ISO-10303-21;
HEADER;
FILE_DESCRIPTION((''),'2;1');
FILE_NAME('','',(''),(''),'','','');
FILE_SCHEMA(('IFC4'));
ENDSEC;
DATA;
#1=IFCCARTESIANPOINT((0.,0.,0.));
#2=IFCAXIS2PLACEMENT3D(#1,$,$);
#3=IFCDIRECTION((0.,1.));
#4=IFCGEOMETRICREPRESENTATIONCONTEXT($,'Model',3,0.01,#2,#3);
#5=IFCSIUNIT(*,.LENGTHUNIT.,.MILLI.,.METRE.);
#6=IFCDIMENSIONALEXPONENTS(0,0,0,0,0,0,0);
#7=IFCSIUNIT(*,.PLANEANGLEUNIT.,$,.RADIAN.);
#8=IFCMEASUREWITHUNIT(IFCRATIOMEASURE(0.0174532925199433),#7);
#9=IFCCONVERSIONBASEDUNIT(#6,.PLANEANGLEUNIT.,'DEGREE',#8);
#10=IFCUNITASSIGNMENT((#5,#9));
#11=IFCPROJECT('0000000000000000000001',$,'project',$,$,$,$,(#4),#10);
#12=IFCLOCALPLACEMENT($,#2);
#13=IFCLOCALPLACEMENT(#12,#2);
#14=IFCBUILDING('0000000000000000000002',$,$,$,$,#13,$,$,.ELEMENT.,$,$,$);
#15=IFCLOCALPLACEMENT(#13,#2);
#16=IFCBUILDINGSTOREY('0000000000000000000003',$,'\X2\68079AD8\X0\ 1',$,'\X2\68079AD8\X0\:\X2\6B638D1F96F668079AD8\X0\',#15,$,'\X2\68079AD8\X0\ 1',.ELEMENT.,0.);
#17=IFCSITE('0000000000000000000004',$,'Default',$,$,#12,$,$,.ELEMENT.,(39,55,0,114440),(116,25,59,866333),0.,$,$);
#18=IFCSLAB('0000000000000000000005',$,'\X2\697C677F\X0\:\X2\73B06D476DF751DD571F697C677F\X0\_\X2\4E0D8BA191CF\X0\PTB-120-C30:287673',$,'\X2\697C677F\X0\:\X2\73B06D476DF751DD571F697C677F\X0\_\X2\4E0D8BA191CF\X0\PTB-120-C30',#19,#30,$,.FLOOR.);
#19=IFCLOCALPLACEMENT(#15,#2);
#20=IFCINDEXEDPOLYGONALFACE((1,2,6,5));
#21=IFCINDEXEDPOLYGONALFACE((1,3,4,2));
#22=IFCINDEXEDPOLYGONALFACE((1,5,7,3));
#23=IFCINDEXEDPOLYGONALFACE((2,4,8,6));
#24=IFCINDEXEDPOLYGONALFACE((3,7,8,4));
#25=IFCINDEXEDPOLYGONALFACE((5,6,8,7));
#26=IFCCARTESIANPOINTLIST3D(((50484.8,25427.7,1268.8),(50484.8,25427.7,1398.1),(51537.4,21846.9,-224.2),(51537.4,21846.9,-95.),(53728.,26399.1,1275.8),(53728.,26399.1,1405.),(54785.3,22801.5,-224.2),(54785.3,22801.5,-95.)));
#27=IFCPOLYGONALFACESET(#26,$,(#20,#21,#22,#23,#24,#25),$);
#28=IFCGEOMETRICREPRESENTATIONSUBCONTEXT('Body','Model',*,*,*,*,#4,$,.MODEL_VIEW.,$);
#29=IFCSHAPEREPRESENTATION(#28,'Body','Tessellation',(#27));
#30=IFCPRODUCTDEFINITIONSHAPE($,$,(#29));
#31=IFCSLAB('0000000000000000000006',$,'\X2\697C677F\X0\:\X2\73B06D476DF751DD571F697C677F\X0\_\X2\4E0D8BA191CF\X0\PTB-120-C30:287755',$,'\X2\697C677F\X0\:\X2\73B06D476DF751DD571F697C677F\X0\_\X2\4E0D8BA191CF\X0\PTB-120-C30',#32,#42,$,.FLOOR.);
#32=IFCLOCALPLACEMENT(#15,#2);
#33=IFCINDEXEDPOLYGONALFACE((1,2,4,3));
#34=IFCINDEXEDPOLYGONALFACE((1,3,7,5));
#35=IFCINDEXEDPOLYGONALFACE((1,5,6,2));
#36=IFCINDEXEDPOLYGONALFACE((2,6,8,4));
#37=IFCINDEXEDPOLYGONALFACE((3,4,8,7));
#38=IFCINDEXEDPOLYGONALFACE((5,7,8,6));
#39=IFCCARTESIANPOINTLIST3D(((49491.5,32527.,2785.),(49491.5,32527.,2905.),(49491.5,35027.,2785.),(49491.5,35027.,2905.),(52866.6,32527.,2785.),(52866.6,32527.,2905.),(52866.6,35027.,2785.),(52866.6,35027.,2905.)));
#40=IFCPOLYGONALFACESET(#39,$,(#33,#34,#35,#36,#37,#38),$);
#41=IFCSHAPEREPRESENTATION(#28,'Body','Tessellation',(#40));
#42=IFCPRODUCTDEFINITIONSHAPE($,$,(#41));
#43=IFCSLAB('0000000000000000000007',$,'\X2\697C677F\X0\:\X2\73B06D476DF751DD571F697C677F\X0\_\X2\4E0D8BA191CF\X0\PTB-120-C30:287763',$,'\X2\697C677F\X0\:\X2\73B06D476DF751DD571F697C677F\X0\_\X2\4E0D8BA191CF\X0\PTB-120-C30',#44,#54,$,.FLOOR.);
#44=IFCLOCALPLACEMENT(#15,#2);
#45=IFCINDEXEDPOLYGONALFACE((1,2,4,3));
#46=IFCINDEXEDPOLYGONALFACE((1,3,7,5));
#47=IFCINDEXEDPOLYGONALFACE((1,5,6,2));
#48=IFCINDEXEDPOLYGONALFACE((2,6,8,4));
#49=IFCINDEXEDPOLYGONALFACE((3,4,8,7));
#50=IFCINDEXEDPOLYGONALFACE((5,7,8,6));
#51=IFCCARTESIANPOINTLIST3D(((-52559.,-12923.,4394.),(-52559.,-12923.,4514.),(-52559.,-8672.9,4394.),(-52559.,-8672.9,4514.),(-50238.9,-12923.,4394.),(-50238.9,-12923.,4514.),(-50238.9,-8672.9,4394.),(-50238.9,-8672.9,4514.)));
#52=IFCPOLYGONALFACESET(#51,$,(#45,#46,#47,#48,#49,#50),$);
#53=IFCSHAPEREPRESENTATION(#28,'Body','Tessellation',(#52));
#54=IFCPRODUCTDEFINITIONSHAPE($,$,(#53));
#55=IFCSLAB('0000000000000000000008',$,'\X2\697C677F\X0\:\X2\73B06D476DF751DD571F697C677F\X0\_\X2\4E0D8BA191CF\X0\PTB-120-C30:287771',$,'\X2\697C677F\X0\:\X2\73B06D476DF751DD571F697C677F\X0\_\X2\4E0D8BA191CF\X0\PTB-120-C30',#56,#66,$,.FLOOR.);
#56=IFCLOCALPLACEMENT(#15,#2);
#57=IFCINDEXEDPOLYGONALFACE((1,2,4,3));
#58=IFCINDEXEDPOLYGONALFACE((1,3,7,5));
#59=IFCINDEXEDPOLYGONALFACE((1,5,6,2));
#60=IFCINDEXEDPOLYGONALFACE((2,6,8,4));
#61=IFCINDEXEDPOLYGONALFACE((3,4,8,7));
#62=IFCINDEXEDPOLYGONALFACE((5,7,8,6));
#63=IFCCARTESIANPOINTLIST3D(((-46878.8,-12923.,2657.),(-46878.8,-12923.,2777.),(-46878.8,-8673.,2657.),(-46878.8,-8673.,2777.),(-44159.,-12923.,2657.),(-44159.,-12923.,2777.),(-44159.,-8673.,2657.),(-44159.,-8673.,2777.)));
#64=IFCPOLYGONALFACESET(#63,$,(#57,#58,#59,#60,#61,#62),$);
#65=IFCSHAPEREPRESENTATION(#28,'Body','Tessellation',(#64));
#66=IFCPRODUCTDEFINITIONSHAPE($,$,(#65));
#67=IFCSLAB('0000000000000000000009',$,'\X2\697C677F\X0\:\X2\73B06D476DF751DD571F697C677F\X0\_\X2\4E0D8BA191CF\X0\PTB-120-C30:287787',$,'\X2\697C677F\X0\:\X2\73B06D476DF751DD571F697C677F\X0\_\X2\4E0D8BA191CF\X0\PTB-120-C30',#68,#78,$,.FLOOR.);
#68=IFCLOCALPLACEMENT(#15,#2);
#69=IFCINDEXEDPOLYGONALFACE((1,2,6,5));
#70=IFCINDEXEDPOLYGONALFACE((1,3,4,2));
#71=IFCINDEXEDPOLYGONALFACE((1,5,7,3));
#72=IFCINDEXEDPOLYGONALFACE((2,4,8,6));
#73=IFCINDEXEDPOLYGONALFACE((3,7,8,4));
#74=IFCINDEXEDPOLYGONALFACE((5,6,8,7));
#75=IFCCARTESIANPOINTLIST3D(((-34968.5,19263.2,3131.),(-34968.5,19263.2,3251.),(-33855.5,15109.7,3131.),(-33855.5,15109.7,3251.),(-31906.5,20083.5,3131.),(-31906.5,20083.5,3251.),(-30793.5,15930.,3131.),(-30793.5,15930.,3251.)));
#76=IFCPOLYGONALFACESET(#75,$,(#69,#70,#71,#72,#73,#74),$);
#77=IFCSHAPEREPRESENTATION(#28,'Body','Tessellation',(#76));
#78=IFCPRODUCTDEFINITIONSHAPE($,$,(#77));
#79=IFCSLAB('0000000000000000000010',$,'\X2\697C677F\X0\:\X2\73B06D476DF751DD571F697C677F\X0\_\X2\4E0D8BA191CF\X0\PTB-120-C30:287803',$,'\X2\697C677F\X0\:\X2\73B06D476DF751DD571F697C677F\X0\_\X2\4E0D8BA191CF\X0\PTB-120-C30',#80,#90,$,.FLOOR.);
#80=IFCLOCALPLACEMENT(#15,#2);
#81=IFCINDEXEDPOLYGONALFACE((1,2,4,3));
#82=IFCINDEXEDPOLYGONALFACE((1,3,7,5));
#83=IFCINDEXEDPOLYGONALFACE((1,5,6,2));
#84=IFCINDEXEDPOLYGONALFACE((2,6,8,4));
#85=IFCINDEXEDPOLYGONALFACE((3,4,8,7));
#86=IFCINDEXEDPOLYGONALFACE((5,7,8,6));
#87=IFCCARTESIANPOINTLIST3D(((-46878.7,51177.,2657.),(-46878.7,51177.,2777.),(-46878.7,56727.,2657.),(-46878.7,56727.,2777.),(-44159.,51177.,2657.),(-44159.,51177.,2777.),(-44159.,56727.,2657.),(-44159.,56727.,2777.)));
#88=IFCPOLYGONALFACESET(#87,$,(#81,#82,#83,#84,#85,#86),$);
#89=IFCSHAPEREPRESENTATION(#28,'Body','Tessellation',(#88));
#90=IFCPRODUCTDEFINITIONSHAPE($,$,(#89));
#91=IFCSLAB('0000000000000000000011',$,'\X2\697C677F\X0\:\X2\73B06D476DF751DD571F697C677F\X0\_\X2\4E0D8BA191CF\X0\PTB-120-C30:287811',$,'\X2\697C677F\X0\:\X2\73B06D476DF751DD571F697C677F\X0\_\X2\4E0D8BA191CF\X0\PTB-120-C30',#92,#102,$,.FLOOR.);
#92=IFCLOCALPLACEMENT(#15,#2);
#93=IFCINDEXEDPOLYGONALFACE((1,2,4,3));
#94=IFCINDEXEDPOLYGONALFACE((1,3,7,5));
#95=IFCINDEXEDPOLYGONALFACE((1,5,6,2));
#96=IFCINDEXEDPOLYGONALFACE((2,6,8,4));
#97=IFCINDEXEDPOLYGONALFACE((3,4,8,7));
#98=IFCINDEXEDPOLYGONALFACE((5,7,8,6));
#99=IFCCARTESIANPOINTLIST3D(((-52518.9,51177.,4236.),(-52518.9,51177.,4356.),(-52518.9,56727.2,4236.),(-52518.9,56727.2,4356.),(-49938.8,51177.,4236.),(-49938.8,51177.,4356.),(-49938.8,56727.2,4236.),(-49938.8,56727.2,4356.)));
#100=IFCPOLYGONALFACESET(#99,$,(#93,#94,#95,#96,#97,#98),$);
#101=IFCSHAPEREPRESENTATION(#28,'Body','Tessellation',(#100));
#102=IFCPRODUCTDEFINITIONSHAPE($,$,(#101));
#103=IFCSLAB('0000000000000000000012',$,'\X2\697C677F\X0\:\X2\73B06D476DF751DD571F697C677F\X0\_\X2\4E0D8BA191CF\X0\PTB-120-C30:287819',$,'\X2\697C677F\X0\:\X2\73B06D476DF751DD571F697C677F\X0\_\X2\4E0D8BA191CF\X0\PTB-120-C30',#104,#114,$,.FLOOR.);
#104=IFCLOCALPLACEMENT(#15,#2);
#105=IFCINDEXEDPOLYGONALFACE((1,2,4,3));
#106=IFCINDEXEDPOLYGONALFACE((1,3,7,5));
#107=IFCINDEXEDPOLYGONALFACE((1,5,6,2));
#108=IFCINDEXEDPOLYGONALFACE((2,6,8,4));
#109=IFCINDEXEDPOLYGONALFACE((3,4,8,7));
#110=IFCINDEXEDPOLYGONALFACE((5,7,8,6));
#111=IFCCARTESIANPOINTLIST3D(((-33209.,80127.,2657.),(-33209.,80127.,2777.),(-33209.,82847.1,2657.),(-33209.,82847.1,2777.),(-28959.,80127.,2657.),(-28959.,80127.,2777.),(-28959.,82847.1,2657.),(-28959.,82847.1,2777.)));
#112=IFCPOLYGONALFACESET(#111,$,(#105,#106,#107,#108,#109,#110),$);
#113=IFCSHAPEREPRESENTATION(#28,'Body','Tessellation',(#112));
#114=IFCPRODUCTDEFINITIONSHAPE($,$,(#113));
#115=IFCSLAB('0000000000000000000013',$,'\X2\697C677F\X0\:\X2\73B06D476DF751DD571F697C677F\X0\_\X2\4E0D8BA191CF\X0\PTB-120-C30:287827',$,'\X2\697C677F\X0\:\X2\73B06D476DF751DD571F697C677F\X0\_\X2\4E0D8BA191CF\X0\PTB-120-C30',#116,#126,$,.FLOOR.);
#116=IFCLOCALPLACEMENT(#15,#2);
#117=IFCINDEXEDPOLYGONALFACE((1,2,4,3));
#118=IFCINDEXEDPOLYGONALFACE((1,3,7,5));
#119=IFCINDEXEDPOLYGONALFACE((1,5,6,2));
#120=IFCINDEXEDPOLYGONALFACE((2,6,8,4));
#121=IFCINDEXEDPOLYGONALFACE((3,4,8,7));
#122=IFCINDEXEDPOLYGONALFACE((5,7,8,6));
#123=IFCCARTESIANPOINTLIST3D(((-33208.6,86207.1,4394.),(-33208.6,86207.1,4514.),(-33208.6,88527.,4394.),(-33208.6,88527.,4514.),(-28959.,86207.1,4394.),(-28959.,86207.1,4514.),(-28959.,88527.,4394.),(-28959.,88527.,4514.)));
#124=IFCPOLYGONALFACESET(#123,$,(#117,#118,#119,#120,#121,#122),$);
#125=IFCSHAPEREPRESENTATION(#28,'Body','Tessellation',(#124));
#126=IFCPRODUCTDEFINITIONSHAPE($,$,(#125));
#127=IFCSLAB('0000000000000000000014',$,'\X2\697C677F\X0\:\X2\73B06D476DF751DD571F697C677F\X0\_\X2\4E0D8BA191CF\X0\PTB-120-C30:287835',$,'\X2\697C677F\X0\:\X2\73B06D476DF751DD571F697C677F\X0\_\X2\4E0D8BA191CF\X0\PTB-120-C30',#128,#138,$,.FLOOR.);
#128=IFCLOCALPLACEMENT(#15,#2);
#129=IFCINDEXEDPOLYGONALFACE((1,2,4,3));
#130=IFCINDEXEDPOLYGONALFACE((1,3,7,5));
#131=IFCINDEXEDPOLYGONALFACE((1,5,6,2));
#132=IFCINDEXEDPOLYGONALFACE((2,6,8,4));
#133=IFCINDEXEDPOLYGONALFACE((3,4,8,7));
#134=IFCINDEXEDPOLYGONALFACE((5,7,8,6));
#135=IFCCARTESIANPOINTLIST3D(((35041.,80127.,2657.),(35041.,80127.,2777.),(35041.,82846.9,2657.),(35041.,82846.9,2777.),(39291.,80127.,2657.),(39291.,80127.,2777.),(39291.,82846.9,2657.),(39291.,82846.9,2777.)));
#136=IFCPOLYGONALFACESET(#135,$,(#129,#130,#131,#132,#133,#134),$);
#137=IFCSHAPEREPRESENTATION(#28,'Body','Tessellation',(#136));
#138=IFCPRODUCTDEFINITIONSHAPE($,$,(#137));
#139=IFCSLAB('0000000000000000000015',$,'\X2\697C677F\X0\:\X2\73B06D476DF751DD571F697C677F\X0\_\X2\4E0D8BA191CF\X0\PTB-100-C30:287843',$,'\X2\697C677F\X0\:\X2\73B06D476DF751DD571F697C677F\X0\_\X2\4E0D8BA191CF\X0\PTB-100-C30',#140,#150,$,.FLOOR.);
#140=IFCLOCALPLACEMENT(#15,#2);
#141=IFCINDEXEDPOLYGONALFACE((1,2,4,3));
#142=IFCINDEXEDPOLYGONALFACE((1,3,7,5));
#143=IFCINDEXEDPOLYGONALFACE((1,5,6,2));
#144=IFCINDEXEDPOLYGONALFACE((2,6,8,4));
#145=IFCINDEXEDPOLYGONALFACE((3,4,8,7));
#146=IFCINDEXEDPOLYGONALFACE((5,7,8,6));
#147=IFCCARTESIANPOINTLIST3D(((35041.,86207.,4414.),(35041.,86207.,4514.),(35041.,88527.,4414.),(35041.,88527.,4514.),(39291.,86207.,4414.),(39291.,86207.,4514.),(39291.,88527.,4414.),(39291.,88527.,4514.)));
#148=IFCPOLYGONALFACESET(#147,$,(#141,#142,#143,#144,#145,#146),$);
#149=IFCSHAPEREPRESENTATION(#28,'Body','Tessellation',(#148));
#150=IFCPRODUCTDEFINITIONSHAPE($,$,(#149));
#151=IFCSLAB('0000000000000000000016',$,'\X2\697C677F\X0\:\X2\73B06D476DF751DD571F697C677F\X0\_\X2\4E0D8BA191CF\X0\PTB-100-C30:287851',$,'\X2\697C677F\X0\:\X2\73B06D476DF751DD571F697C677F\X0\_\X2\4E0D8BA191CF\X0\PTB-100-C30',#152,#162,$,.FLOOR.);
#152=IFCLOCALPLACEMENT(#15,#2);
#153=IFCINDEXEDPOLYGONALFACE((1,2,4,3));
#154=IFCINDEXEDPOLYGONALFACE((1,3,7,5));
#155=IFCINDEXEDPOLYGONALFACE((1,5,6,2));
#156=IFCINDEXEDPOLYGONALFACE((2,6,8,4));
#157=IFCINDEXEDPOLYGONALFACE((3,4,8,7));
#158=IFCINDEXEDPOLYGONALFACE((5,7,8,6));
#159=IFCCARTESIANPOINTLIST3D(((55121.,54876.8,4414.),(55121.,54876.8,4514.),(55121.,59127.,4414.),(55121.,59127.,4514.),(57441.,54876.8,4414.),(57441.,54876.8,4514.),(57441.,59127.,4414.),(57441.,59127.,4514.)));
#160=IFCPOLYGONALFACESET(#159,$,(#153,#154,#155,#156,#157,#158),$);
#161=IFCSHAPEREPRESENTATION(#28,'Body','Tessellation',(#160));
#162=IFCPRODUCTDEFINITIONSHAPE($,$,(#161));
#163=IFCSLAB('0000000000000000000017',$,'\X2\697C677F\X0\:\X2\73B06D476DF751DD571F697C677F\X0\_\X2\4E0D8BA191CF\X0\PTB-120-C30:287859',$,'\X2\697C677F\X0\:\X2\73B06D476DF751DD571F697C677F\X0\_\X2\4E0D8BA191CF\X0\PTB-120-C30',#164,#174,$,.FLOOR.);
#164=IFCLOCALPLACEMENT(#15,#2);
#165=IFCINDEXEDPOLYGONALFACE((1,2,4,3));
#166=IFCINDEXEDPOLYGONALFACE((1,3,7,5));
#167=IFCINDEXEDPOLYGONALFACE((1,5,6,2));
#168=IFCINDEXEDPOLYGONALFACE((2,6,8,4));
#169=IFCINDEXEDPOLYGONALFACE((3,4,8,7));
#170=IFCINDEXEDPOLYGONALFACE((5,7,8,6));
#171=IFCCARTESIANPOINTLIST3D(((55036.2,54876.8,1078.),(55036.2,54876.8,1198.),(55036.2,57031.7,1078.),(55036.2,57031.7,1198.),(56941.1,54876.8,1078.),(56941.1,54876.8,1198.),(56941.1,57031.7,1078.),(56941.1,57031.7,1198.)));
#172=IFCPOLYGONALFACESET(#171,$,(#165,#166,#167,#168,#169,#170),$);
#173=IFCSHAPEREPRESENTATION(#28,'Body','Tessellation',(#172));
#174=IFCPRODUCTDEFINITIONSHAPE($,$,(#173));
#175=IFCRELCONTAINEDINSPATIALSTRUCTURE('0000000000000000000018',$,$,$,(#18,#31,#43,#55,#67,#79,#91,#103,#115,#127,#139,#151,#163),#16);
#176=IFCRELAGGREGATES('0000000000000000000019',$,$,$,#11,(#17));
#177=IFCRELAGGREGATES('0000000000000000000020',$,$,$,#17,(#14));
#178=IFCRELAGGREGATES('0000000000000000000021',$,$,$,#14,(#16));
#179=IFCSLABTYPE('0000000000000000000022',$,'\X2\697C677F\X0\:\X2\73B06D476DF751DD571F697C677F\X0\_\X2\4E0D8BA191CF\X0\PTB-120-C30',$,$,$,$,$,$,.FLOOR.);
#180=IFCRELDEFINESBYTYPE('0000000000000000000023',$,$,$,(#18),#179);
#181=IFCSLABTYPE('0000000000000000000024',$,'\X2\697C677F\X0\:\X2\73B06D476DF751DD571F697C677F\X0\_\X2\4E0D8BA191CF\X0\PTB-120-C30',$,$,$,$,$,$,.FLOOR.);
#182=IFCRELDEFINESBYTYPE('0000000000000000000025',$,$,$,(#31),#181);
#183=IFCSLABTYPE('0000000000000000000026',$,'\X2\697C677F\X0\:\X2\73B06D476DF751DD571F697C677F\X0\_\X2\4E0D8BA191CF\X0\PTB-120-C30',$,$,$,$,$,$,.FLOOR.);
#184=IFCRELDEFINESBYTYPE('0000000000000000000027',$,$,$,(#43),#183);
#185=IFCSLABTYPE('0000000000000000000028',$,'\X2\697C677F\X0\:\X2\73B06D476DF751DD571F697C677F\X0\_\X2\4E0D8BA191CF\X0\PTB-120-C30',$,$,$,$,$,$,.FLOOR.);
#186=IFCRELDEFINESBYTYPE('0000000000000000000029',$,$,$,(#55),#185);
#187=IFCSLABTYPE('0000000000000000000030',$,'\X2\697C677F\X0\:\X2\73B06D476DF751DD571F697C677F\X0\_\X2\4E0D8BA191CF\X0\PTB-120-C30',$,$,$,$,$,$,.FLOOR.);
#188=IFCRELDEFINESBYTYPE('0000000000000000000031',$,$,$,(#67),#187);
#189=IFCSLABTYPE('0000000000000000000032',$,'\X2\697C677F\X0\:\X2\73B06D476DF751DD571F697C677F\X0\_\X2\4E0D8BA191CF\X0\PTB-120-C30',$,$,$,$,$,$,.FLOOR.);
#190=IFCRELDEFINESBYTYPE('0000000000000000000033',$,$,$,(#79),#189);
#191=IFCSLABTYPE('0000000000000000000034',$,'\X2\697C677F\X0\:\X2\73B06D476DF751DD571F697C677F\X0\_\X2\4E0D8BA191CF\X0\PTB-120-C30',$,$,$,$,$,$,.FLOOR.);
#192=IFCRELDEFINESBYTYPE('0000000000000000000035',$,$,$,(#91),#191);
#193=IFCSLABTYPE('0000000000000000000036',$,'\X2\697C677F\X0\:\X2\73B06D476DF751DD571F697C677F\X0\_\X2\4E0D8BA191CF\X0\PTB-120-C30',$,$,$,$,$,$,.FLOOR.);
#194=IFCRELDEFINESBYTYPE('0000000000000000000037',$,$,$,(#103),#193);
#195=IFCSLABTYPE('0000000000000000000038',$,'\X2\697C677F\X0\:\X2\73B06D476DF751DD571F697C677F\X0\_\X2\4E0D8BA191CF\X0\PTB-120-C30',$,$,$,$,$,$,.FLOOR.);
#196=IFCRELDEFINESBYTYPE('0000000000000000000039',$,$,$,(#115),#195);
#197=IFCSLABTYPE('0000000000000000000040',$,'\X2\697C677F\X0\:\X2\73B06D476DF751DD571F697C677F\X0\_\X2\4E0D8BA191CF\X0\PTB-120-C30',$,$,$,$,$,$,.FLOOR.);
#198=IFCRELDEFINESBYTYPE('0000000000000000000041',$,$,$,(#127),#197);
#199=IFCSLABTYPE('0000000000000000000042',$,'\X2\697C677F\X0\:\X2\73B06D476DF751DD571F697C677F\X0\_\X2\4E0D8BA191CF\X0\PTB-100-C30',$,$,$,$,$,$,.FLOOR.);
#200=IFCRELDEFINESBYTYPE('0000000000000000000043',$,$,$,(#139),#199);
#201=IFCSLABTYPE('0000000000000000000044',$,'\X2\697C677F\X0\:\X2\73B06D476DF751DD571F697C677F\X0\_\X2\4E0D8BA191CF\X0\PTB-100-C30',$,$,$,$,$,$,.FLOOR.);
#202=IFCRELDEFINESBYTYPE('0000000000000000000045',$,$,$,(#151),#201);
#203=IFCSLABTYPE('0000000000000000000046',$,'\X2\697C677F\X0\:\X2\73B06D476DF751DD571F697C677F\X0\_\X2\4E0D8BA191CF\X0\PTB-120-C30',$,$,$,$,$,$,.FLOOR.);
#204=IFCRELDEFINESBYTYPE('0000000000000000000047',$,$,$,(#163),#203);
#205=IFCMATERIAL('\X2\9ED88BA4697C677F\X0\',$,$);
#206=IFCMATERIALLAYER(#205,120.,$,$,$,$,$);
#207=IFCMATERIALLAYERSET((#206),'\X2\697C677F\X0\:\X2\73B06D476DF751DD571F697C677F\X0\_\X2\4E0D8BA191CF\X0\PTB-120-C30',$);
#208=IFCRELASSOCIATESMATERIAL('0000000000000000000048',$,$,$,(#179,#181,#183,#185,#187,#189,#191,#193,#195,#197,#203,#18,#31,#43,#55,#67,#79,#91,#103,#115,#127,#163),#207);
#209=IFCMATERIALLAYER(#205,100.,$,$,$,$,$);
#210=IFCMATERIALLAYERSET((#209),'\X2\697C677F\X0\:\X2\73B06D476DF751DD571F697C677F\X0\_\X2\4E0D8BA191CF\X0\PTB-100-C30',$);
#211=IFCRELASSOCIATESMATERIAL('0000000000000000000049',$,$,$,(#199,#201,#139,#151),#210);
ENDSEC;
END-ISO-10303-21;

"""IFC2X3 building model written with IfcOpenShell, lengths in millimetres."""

from ifc_helpers import new_model, entity, si_unit, converted_unit, direction, frame, frame_2d, origin, origin_2d_with_axis, place, context, subcontext, project, spatial, polyline, rectangle, outline, extrude, clip, halfspace, material, layer, layer_set, layer_usage, type_object, element, save


model = new_model("IFC2X3")

# Units and contexts
model_context = context("Model", 3, precision=0.01, world=origin(), true_north=direction((0.0, 1.0)))
body_context = subcontext(model_context, "Body", "Model", "MODEL_VIEW")
ifc_project = project(units=[si_unit("LENGTHUNIT", "METRE", prefix="MILLI"), converted_unit("PLANEANGLEUNIT", "DEGREE", entity("IfcRatioMeasure", 0.0174532925199433), si_unit("PLANEANGLEUNIT", "RADIAN"), dimensions=[0, 0, 0, 0, 0, 0, 0])], contexts=[model_context])

# Site, building, storey
site_placement = place(None, origin())
site = spatial("IfcSite", under=ifc_project, at=site_placement, Name="Default", CompositionType="ELEMENT", RefLatitude=(39, 55, 0, 114440), RefLongitude=(116, 25, 59, 866333), RefElevation=0.0)
building_placement = place(site_placement, origin())
building = spatial("IfcBuilding", under=site, at=building_placement, CompositionType="ELEMENT")
storey_placement = place(building_placement, origin())
storey = spatial("IfcBuildingStorey", under=building, at=storey_placement, Name="标高 1", ObjectType="标高:正负零标高", LongName="标高 1", CompositionType="ELEMENT", Elevation=0.0)

# Slabs
ifc_material = material(Name="默认楼板")
ifc_layer_1 = layer(ifc_material, 120.0)
ifc_layer_set_1 = layer_set([ifc_layer_1], Name="楼板:现浇混凝土楼板_不计量PTB-120-C30")
ifc_layer_usage_1 = layer_usage(ifc_layer_set_1, "AXIS3", "POSITIVE", 0.0)
slab_type_1 = type_object("IfcSlabType", Name="楼板:现浇混凝土楼板_不计量PTB-120-C30", PredefinedType="FLOOR", material=ifc_layer_set_1)
slab_1_placement = place(building_placement, origin())
element("IfcSlab", 1, at=slab_1_placement, inside=storey, type_object=slab_type_1, material=ifc_layer_usage_1, Name="楼板:现浇混凝土楼板_不计量PTB-120-C30:287673", ObjectType="楼板:现浇混凝土楼板_不计量PTB-120-C30", PredefinedType="FLOOR", context=body_context, shape_type="Clipping", body=[
    clip(clip(extrude(outline(polyline([(-2024.1, -1692.7), (2014.5, -1692.7), (2014.7, 1692.6), (-2005.2, 1692.8), (-2024.1, -1692.7)])), frame((52633.9, 24118.8, 653.3), z_axis=(-0.104745, 0.35634, -0.928467), x_axis=(0.261785, -0.890797, -0.371416)), (0.371416, -0.000023, 0.928467), 139.2), halfspace(frame((51537.4, 21846.9, -224.2), z_axis=(-0.104745, 0.35634, -0.928467), x_axis=(-0.261843, 0.89078, 0.371416)), False)), halfspace(frame((51537.4, 21846.9, -95.0), z_axis=(0.104745, -0.35634, 0.928467), x_axis=(0.261843, -0.89078, -0.371416)), False)),
])
ifc_layer_usage_2 = layer_usage(ifc_layer_set_1, "AXIS3", "POSITIVE", 0.0)
slab_type_2 = type_object("IfcSlabType", Name="楼板:现浇混凝土楼板_不计量PTB-120-C30", PredefinedType="FLOOR", material=ifc_layer_set_1)
slab_2_placement = place(building_placement, origin())
element("IfcSlab", 2, at=slab_2_placement, inside=storey, type_object=slab_type_2, material=ifc_layer_usage_2, Name="楼板:现浇混凝土楼板_不计量PTB-120-C30:287755", ObjectType="楼板:现浇混凝土楼板_不计量PTB-120-C30", PredefinedType="FLOOR", context=body_context, shape_type="SweptSolid", body=[
    extrude(outline(polyline([(-1687.6, -1250.0), (1687.6, -1250.0), (1687.5, 1250.0), (-1687.6, 1250.0), (-1687.6, -1250.0)])), frame((51179.1, 33777.0, 2905.0), z_axis=(0.0, 0.0, -1.0), x_axis=(-1.0, 0.0, 0.0)), (0.0, 0.0, 1.0), 120.0),
])
ifc_layer_usage_3 = layer_usage(ifc_layer_set_1, "AXIS3", "POSITIVE", 0.0)
slab_type_3 = type_object("IfcSlabType", Name="楼板:现浇混凝土楼板_不计量PTB-120-C30", PredefinedType="FLOOR", material=ifc_layer_set_1)
slab_3_placement = place(building_placement, origin())
element("IfcSlab", 3, at=slab_3_placement, inside=storey, type_object=slab_type_3, material=ifc_layer_usage_3, Name="楼板:现浇混凝土楼板_不计量PTB-120-C30:287763", ObjectType="楼板:现浇混凝土楼板_不计量PTB-120-C30", PredefinedType="FLOOR", context=body_context, shape_type="SweptSolid", body=[
    extrude(rectangle(XDim=4250.1, YDim=2320.1, at=frame_2d((0.0, 0.0), x_axis=(1.0, 0.0))), frame((-51399.0, -10798.0, 4514.0), z_axis=(0.0, 0.0, -1.0), x_axis=(0.0, 1.0, 0.0)), (0.0, 0.0, 1.0), 120.0),
])
ifc_layer_usage_4 = layer_usage(ifc_layer_set_1, "AXIS3", "POSITIVE", 0.0)
slab_type_4 = type_object("IfcSlabType", Name="楼板:现浇混凝土楼板_不计量PTB-120-C30", PredefinedType="FLOOR", material=ifc_layer_set_1)
slab_4_placement = place(building_placement, origin())
element("IfcSlab", 4, at=slab_4_placement, inside=storey, type_object=slab_type_4, material=ifc_layer_usage_4, Name="楼板:现浇混凝土楼板_不计量PTB-120-C30:287771", ObjectType="楼板:现浇混凝土楼板_不计量PTB-120-C30", PredefinedType="FLOOR", context=body_context, shape_type="SweptSolid", body=[
    extrude(rectangle(XDim=4250.0, YDim=2719.8, at=frame_2d((0.0, 0.0), x_axis=(1.0, 0.0))), frame((-45518.9, -10798.0, 2777.0), z_axis=(0.0, 0.0, -1.0), x_axis=(0.0, 1.0, 0.0)), (0.0, 0.0, 1.0), 120.0),
])
ifc_layer_usage_5 = layer_usage(ifc_layer_set_1, "AXIS3", "POSITIVE", 0.0)
slab_type_5 = type_object("IfcSlabType", Name="楼板:现浇混凝土楼板_不计量PTB-120-C30", PredefinedType="FLOOR", material=ifc_layer_set_1)
slab_5_placement = place(building_placement, origin())
element("IfcSlab", 5, at=slab_5_placement, inside=storey, type_object=slab_type_5, material=ifc_layer_usage_5, Name="楼板:现浇混凝土楼板_不计量PTB-120-C30:287787", ObjectType="楼板:现浇混凝土楼板_不计量PTB-120-C30", PredefinedType="FLOOR", context=body_context, shape_type="SweptSolid", body=[
    extrude(outline(polyline([(-2149.9, -1585.0), (2150.1, -1585.0), (2149.9, 1585.0), (-2150.1, 1585.0), (-2149.9, -1585.0)])), frame((-32881.0, 17596.6, 3251.0), z_axis=(0.0, 0.0, -1.0), x_axis=(0.258819, -0.965926, 0.0)), (0.0, 0.0, 1.0), 120.0),
])
ifc_layer_usage_6 = layer_usage(ifc_layer_set_1, "AXIS3", "POSITIVE", 0.0)
slab_type_6 = type_object("IfcSlabType", Name="楼板:现浇混凝土楼板_不计量PTB-120-C30", PredefinedType="FLOOR", material=ifc_layer_set_1)
slab_6_placement = place(building_placement, origin())
element("IfcSlab", 6, at=slab_6_placement, inside=storey, type_object=slab_type_6, material=ifc_layer_usage_6, Name="楼板:现浇混凝土楼板_不计量PTB-120-C30:287803", ObjectType="楼板:现浇混凝土楼板_不计量PTB-120-C30", PredefinedType="FLOOR", context=body_context, shape_type="SweptSolid", body=[
    extrude(rectangle(XDim=5550.0, YDim=2719.7, at=origin_2d_with_axis()), frame((-45518.9, 53952.0, 2777.0), z_axis=(0.0, 0.0, -1.0), x_axis=(0.0, 1.0, 0.0)), (0.0, 0.0, 1.0), 120.0),
])
ifc_layer_usage_7 = layer_usage(ifc_layer_set_1, "AXIS3", "POSITIVE", 0.0)
slab_type_7 = type_object("IfcSlabType", Name="楼板:现浇混凝土楼板_不计量PTB-120-C30", PredefinedType="FLOOR", material=ifc_layer_set_1)
slab_7_placement = place(building_placement, origin())
element("IfcSlab", 7, at=slab_7_placement, inside=storey, type_object=slab_type_7, material=ifc_layer_usage_7, Name="楼板:现浇混凝土楼板_不计量PTB-120-C30:287811", ObjectType="楼板:现浇混凝土楼板_不计量PTB-120-C30", PredefinedType="FLOOR", context=body_context, shape_type="SweptSolid", body=[
    extrude(rectangle(XDim=5550.2, YDim=2580.0, at=origin_2d_with_axis()), frame((-51228.8, 53952.1, 4356.0), z_axis=(0.0, 0.0, -1.0), x_axis=(0.0, 1.0, 0.0)), (0.0, 0.0, 1.0), 120.0),
])
ifc_layer_usage_8 = layer_usage(ifc_layer_set_1, "AXIS3", "POSITIVE", 0.0)
slab_type_8 = type_object("IfcSlabType", Name="楼板:现浇混凝土楼板_不计量PTB-120-C30", PredefinedType="FLOOR", material=ifc_layer_set_1)
slab_8_placement = place(building_placement, origin())
element("IfcSlab", 8, at=slab_8_placement, inside=storey, type_object=slab_type_8, material=ifc_layer_usage_8, Name="楼板:现浇混凝土楼板_不计量PTB-120-C30:287819", ObjectType="楼板:现浇混凝土楼板_不计量PTB-120-C30", PredefinedType="FLOOR", context=body_context, shape_type="SweptSolid", body=[
    extrude(rectangle(XDim=2720.1, YDim=4250.0, at=frame_2d((0.0, 0.0), x_axis=(1.0, 0.0))), frame((-31084.0, 81487.1, 2777.0), z_axis=(0.0, 0.0, -1.0), x_axis=(0.0, 1.0, 0.0)), (0.0, 0.0, 1.0), 120.0),
])
ifc_layer_usage_9 = layer_usage(ifc_layer_set_1, "AXIS3", "POSITIVE", 0.0)
slab_type_9 = type_object("IfcSlabType", Name="楼板:现浇混凝土楼板_不计量PTB-120-C30", PredefinedType="FLOOR", material=ifc_layer_set_1)
slab_9_placement = place(building_placement, origin())
element("IfcSlab", 9, at=slab_9_placement, inside=storey, type_object=slab_type_9, material=ifc_layer_usage_9, Name="楼板:现浇混凝土楼板_不计量PTB-120-C30:287827", ObjectType="楼板:现浇混凝土楼板_不计量PTB-120-C30", PredefinedType="FLOOR", context=body_context, shape_type="SweptSolid", body=[
    extrude(rectangle(XDim=2319.9, YDim=4249.6, at=frame_2d((0.0, 0.0), x_axis=(1.0, 0.0))), frame((-31083.8, 87367.0, 4514.0), z_axis=(0.0, 0.0, -1.0), x_axis=(0.0, 1.0, 0.0)), (0.0, 0.0, 1.0), 120.0),
])
ifc_layer_usage_10 = layer_usage(ifc_layer_set_1, "AXIS3", "POSITIVE", 0.0)
slab_type_10 = type_object("IfcSlabType", Name="楼板:现浇混凝土楼板_不计量PTB-120-C30", PredefinedType="FLOOR", material=ifc_layer_set_1)
slab_10_placement = place(building_placement, origin())
element("IfcSlab", 10, at=slab_10_placement, inside=storey, type_object=slab_type_10, material=ifc_layer_usage_10, Name="楼板:现浇混凝土楼板_不计量PTB-120-C30:287835", ObjectType="楼板:现浇混凝土楼板_不计量PTB-120-C30", PredefinedType="FLOOR", context=body_context, shape_type="SweptSolid", body=[
    extrude(rectangle(XDim=2719.9, YDim=4250.0, at=frame_2d((0.0, 0.0), x_axis=(1.0, 0.0))), frame((37166.0, 81486.9, 2777.0), z_axis=(0.0, 0.0, -1.0), x_axis=(0.0, 1.0, 0.0)), (0.0, 0.0, 1.0), 120.0),
])
ifc_layer_2 = layer(ifc_material, 100.0)
ifc_layer_set_2 = layer_set([ifc_layer_2], Name="楼板:现浇混凝土楼板_不计量PTB-100-C30")
ifc_layer_usage_11 = layer_usage(ifc_layer_set_2, "AXIS3", "POSITIVE", 0.0)
slab_type_11 = type_object("IfcSlabType", Name="楼板:现浇混凝土楼板_不计量PTB-100-C30", PredefinedType="FLOOR", material=ifc_layer_set_2)
slab_11_placement = place(building_placement, origin())
element("IfcSlab", 11, at=slab_11_placement, inside=storey, type_object=slab_type_11, material=ifc_layer_usage_11, Name="楼板:现浇混凝土楼板_不计量PTB-100-C30:287843", ObjectType="楼板:现浇混凝土楼板_不计量PTB-100-C30", PredefinedType="FLOOR", context=body_context, shape_type="SweptSolid", body=[
    extrude(rectangle(XDim=2320.0, YDim=4250.0, at=frame_2d((0.0, 0.0), x_axis=(1.0, 0.0))), frame((37166.0, 87367.0, 4514.0), z_axis=(0.0, 0.0, -1.0), x_axis=(0.0, 1.0, 0.0)), (0.0, 0.0, 1.0), 100.0),
])
ifc_layer_usage_12 = layer_usage(ifc_layer_set_2, "AXIS3", "POSITIVE", 0.0)
slab_type_12 = type_object("IfcSlabType", Name="楼板:现浇混凝土楼板_不计量PTB-100-C30", PredefinedType="FLOOR", material=ifc_layer_set_2)
slab_12_placement = place(building_placement, origin())
element("IfcSlab", 12, at=slab_12_placement, inside=storey, type_object=slab_type_12, material=ifc_layer_usage_12, Name="楼板:现浇混凝土楼板_不计量PTB-100-C30:287851", ObjectType="楼板:现浇混凝土楼板_不计量PTB-100-C30", PredefinedType="FLOOR", context=body_context, shape_type="SweptSolid", body=[
    extrude(rectangle(XDim=4250.2, YDim=2320.0, at=frame_2d((0.0, 0.0), x_axis=(1.0, 0.0))), frame((56281.0, 57001.9, 4514.0), z_axis=(0.0, 0.0, -1.0), x_axis=(0.0, 1.0, 0.0)), (0.0, 0.0, 1.0), 100.0),
])
ifc_layer_usage_13 = layer_usage(ifc_layer_set_1, "AXIS3", "POSITIVE", 0.0)
slab_type_13 = type_object("IfcSlabType", Name="楼板:现浇混凝土楼板_不计量PTB-120-C30", PredefinedType="FLOOR", material=ifc_layer_set_1)
slab_13_placement = place(building_placement, origin())
element("IfcSlab", 13, at=slab_13_placement, inside=storey, type_object=slab_type_13, material=ifc_layer_usage_13, Name="楼板:现浇混凝土楼板_不计量PTB-120-C30:287859", ObjectType="楼板:现浇混凝土楼板_不计量PTB-120-C30", PredefinedType="FLOOR", context=body_context, shape_type="SweptSolid", body=[
    extrude(rectangle(XDim=2154.8, YDim=1905.0, at=frame_2d((0.0, 0.0), x_axis=(1.0, 0.0))), frame((55988.6, 55954.2, 1198.0), z_axis=(0.0, 0.0, -1.0), x_axis=(0.0, 1.0, 0.0)), (0.0, 0.0, 1.0), 120.0),
])

save(model, "model.ifc")
